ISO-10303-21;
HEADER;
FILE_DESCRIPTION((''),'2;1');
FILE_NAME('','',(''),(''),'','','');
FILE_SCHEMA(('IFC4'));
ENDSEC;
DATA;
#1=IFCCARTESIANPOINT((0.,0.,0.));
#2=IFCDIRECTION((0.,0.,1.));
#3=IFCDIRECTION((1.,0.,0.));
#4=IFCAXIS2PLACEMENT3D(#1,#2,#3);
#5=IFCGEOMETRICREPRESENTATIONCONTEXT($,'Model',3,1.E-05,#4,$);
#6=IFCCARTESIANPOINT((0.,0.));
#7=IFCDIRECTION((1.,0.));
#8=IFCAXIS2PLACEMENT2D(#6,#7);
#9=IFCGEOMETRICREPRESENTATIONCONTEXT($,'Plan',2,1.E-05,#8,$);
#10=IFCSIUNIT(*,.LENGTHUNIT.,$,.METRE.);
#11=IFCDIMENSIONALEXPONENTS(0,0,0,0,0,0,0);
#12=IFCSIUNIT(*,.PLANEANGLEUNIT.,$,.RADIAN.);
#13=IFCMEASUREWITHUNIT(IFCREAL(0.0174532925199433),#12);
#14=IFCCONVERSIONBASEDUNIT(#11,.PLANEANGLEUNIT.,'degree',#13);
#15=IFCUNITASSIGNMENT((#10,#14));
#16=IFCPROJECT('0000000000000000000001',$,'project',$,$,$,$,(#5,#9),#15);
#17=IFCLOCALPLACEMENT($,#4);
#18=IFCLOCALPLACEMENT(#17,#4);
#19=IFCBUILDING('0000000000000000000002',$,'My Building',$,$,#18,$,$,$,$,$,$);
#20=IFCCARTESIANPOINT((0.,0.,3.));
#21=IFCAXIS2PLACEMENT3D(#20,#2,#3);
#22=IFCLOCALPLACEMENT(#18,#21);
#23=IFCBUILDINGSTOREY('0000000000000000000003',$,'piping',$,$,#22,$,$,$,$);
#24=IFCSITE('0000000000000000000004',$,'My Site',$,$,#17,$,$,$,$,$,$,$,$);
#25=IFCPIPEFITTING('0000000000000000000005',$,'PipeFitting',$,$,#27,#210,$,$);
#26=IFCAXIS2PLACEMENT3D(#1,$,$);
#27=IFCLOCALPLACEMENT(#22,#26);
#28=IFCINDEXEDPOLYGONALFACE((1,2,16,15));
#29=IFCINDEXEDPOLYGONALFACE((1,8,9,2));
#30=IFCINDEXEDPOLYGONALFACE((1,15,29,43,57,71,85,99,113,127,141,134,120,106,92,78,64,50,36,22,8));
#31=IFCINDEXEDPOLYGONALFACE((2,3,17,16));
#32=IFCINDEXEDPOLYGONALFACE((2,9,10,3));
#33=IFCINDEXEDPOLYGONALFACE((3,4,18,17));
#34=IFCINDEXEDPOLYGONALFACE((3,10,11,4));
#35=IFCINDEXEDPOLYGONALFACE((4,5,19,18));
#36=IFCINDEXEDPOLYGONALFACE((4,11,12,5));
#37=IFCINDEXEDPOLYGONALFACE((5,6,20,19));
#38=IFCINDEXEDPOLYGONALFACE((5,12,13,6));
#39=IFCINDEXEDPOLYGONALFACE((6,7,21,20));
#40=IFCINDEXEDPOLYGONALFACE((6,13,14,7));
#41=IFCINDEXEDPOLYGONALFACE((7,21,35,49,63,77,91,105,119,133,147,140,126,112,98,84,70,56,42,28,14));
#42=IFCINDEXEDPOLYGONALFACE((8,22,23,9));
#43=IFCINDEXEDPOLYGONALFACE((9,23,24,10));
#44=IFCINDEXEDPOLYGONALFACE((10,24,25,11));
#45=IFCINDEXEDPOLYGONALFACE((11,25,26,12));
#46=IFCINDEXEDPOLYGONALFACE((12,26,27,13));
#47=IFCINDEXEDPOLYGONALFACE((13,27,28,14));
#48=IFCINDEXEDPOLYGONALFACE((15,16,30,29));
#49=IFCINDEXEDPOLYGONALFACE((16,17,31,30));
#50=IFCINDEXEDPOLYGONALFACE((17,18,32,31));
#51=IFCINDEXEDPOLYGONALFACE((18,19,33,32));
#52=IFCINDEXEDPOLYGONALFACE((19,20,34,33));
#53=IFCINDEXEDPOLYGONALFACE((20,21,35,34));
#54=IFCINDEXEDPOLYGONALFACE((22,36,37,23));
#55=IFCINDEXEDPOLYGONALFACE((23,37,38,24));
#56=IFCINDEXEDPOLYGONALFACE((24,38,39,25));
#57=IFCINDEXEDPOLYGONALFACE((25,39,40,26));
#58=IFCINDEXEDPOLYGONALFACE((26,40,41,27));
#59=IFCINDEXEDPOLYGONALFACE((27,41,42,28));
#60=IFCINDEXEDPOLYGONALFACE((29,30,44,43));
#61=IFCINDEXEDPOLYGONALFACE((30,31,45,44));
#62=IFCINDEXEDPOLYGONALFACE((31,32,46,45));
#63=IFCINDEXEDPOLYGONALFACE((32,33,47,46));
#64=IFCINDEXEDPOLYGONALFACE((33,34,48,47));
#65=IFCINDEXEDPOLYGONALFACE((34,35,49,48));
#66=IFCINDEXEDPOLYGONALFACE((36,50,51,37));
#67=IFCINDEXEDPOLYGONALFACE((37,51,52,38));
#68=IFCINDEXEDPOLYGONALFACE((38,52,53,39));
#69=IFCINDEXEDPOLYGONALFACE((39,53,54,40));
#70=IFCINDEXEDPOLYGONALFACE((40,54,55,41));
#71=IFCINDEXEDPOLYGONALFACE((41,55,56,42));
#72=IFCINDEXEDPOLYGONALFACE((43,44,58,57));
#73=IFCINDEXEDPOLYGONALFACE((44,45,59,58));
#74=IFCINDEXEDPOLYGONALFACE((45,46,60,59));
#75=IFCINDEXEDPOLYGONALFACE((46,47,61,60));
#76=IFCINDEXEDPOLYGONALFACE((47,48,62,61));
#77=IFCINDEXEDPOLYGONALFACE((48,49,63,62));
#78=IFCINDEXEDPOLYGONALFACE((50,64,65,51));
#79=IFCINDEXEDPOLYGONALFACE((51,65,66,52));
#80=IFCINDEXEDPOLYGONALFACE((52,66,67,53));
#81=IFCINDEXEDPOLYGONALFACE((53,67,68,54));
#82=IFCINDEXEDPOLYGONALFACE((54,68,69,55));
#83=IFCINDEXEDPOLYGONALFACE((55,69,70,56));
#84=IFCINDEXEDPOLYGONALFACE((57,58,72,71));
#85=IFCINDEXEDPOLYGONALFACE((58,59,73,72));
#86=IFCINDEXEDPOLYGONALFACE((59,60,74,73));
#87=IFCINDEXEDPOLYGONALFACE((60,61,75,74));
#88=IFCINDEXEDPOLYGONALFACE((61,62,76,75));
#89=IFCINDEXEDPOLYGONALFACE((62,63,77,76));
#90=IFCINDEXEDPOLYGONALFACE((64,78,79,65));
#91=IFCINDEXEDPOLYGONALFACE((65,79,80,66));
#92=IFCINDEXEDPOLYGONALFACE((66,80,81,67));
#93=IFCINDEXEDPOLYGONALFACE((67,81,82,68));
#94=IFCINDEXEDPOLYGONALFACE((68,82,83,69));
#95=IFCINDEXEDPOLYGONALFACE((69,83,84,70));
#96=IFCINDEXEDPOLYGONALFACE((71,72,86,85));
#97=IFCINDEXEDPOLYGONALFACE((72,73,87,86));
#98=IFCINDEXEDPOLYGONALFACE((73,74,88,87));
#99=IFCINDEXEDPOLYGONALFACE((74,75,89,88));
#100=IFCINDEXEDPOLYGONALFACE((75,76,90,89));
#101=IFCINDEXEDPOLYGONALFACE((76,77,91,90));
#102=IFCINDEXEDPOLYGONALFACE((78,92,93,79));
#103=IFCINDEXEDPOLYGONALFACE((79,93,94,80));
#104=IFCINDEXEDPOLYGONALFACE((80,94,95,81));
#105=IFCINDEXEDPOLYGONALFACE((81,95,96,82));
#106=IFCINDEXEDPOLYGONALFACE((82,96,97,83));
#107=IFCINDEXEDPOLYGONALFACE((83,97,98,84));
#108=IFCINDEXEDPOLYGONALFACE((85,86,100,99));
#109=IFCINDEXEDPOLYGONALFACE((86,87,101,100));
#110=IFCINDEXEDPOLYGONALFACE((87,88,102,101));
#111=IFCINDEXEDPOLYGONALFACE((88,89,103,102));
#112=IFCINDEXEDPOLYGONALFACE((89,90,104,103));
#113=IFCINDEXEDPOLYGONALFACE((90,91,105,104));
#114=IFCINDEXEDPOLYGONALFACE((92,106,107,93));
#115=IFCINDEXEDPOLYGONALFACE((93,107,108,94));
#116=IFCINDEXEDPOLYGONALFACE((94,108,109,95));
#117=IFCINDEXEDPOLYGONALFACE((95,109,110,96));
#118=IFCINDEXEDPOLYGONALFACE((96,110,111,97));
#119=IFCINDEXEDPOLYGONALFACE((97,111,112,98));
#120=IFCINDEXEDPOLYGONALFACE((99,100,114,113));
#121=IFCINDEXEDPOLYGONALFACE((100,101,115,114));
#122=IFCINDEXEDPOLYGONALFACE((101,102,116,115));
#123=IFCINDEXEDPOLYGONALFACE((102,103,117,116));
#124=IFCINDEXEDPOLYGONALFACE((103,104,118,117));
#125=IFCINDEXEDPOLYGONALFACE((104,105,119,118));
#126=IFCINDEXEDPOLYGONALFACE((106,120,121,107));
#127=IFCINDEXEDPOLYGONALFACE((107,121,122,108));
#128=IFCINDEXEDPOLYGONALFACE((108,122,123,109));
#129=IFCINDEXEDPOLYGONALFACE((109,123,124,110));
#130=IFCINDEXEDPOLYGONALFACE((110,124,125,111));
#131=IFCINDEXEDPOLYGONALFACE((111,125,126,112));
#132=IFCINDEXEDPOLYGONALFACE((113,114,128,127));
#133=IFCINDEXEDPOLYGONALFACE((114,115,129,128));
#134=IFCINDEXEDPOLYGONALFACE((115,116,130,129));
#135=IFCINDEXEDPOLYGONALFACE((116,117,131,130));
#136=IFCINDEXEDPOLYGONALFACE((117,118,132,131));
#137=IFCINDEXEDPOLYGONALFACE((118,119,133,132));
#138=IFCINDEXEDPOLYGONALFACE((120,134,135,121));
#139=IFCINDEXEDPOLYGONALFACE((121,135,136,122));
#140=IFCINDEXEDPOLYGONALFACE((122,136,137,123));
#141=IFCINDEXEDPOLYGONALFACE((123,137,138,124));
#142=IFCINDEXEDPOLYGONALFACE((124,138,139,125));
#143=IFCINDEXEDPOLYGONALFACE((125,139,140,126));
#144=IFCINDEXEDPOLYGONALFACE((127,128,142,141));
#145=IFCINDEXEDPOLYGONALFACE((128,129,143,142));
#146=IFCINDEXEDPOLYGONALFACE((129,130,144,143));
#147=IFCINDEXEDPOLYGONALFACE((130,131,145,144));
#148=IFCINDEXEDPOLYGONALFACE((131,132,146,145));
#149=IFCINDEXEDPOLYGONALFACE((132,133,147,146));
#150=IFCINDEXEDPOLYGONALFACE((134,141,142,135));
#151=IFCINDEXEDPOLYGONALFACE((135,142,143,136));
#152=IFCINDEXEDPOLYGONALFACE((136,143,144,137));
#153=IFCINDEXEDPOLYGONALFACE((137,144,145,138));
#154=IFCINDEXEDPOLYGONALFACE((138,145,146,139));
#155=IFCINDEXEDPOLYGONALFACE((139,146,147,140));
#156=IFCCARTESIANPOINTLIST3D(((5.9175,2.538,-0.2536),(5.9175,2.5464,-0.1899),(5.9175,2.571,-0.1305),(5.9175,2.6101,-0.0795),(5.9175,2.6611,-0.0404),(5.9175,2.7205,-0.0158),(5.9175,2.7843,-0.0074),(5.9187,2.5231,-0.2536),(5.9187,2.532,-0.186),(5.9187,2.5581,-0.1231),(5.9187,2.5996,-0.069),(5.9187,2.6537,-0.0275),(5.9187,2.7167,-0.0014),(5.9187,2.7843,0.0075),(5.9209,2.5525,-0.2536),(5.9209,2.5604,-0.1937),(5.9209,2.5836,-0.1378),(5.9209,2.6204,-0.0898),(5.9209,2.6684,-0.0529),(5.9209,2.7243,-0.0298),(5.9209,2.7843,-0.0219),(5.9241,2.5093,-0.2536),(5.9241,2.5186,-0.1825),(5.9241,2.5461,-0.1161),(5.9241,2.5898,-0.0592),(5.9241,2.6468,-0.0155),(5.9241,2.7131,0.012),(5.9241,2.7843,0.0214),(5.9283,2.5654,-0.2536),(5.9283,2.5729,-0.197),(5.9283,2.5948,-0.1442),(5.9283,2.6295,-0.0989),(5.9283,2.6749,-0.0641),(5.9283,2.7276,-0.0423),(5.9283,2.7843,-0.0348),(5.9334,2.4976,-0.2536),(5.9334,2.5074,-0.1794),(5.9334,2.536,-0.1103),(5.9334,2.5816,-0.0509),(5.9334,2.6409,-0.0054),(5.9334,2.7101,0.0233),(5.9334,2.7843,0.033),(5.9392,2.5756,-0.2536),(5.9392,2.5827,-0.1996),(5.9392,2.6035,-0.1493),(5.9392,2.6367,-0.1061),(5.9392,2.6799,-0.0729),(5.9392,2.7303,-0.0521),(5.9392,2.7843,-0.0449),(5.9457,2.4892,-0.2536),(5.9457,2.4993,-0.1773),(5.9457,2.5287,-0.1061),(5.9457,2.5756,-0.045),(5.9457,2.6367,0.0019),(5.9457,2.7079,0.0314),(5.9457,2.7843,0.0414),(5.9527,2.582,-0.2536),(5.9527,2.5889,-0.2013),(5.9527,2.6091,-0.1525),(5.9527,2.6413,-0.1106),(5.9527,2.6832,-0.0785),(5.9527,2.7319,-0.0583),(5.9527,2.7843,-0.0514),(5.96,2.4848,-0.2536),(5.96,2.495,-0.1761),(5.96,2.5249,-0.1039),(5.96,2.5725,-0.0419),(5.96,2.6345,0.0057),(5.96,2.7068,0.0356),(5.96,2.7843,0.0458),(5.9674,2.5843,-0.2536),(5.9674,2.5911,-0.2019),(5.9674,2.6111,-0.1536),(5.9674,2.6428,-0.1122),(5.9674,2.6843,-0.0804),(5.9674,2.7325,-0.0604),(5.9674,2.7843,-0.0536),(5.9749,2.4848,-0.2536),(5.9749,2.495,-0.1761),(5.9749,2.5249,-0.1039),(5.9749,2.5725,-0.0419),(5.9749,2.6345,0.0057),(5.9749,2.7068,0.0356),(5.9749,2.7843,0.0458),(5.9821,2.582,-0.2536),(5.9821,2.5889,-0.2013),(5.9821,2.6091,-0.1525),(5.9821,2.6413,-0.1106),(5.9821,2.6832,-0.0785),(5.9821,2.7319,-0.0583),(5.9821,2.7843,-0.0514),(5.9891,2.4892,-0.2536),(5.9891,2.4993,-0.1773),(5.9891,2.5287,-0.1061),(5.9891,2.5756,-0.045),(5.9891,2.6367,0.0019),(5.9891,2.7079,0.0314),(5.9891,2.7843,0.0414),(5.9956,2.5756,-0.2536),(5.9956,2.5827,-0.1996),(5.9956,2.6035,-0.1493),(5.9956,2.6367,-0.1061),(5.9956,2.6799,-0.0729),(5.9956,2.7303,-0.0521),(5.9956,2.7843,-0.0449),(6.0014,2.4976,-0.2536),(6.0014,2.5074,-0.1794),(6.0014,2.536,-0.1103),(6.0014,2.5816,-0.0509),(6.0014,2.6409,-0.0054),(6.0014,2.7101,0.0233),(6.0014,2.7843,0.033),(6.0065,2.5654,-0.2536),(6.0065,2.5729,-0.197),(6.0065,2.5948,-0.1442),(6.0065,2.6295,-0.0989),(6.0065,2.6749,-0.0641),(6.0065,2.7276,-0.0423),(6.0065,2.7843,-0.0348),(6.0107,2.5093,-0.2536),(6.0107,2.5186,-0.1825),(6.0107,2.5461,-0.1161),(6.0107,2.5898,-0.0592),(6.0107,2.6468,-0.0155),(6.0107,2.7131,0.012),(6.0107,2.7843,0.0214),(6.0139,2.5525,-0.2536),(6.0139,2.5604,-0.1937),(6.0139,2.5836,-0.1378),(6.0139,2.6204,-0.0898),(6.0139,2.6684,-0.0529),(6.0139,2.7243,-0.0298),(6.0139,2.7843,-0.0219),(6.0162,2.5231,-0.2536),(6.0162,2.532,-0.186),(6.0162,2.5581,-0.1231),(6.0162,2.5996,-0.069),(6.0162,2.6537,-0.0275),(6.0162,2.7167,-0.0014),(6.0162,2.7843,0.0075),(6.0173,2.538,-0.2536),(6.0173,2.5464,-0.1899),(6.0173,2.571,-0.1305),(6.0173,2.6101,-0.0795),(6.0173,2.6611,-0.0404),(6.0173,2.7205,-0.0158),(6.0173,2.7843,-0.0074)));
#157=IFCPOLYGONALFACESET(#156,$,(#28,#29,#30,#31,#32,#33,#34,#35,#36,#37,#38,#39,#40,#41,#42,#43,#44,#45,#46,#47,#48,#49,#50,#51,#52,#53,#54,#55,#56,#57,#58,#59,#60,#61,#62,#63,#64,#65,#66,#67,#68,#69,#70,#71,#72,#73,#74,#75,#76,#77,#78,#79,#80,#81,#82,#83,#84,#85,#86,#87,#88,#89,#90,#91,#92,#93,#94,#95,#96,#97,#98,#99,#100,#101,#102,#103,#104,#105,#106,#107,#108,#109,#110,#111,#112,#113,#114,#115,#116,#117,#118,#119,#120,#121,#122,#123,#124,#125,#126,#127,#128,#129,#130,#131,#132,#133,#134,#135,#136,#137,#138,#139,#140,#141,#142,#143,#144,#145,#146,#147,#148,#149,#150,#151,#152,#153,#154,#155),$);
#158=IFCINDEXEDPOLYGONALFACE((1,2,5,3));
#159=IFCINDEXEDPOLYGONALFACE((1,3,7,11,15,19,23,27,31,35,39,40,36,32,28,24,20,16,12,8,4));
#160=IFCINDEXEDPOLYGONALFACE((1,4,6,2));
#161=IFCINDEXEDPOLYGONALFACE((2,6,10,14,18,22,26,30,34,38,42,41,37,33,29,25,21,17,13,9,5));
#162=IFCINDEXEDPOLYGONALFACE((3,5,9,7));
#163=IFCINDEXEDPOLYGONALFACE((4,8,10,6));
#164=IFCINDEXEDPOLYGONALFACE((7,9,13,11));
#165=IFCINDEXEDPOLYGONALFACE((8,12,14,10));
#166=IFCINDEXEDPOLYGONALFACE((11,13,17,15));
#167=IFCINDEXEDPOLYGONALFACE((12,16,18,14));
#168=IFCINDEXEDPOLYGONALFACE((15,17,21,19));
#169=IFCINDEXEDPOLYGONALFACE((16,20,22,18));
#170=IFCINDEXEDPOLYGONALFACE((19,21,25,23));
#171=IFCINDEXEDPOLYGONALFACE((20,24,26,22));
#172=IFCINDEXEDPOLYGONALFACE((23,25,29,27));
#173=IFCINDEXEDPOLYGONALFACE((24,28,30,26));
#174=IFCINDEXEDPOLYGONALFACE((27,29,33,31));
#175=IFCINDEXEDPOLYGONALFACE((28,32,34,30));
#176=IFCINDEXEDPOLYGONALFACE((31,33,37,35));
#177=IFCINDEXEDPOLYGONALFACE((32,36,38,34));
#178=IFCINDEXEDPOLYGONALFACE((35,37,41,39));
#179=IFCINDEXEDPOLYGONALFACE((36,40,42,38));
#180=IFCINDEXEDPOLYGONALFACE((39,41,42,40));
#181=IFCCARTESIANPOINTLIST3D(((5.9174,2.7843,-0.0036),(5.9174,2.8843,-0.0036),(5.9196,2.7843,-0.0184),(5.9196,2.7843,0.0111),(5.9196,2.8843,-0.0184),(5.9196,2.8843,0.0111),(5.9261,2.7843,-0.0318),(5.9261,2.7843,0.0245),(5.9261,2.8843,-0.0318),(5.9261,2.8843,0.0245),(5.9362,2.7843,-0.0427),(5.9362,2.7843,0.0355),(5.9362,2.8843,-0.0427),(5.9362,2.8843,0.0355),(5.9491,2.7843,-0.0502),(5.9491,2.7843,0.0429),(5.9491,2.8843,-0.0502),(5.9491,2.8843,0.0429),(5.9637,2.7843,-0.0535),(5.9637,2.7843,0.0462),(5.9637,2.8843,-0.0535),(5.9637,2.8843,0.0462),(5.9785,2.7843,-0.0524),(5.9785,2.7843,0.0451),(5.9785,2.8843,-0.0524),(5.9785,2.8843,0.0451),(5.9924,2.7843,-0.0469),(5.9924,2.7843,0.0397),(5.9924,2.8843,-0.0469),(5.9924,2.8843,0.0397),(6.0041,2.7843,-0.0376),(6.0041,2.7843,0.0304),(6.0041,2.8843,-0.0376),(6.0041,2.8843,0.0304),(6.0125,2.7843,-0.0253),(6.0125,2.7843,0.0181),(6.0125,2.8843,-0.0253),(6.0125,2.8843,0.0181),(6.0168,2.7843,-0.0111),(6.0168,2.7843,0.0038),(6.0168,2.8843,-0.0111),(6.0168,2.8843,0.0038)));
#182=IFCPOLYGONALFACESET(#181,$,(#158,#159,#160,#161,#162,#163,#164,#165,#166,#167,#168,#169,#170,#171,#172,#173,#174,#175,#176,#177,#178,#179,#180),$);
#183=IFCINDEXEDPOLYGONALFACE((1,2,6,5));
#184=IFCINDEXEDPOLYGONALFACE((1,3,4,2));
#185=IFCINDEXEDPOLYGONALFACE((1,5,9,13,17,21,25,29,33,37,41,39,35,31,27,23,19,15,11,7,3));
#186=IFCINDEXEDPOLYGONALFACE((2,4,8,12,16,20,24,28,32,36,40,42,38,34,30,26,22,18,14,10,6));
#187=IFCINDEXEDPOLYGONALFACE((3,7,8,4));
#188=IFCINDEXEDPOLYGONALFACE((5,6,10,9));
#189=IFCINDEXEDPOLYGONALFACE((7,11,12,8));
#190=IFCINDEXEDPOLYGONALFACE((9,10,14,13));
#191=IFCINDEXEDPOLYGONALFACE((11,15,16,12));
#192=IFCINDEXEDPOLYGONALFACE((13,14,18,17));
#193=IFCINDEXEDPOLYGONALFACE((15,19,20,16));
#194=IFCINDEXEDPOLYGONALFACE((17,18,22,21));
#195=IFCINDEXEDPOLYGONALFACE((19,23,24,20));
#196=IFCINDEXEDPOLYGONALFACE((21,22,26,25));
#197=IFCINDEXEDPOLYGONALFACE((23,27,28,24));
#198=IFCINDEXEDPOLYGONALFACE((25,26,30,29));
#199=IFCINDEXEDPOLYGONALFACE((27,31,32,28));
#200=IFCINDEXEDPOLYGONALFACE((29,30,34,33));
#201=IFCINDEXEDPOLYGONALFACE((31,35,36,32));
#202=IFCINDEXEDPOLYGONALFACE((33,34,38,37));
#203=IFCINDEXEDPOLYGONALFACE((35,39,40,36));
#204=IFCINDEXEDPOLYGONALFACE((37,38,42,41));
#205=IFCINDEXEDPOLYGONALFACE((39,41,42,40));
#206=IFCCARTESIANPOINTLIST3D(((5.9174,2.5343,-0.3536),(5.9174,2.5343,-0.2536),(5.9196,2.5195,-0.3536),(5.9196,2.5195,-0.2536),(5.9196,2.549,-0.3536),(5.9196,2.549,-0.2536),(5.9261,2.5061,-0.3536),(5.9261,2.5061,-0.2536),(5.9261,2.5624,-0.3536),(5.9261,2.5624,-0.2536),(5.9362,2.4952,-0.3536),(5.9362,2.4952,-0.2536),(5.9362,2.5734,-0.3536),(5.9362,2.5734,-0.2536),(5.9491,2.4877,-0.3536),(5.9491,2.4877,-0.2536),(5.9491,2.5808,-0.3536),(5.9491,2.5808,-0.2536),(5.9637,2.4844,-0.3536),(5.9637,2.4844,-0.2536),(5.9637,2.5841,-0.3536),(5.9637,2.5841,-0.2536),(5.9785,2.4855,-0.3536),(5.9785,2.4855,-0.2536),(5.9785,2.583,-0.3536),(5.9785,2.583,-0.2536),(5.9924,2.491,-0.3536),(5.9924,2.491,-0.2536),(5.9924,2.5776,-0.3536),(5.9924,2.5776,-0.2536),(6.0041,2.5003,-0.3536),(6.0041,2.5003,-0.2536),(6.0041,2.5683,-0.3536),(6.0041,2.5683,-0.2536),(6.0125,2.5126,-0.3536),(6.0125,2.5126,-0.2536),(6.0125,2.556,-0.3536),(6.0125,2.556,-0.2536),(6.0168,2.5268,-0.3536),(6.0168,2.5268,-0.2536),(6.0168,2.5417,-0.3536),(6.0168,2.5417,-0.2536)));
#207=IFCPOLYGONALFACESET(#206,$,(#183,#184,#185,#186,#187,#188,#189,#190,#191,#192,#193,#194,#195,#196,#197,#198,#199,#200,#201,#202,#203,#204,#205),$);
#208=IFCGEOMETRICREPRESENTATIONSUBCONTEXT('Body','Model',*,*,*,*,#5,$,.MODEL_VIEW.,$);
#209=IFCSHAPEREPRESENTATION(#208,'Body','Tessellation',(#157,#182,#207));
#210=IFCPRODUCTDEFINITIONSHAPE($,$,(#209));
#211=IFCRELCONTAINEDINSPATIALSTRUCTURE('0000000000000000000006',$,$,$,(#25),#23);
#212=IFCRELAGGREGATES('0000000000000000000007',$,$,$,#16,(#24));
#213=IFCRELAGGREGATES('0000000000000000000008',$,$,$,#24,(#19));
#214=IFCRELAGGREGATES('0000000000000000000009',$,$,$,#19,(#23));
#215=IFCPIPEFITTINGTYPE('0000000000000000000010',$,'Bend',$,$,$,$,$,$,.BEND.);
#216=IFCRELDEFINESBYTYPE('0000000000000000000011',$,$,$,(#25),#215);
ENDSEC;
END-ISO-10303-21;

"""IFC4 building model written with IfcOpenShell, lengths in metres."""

from ifc_helpers import new_model, entity, si_unit, converted_unit, frame, origin_with_axes, origin_2d_with_axis, place, context, subcontext, project, spatial, circle, extrude, source, transform, mapped, type_object, type_shapes, element, save


model = new_model("IFC4")

# Units and contexts
model_context = context("Model", 3, precision=1e-05, world=origin_with_axes())
plan_context = context("Plan", 2, precision=1e-05, world=origin_2d_with_axis())
body_context = subcontext(model_context, "Body", "Model", "MODEL_VIEW")
ifc_project = project(units=[si_unit("LENGTHUNIT", "METRE"), converted_unit("PLANEANGLEUNIT", "degree", entity("IfcReal", 0.0174532925199433), si_unit("PLANEANGLEUNIT", "RADIAN"), dimensions=[0, 0, 0, 0, 0, 0, 0])], contexts=[model_context, plan_context])

# Site, building, storey
site_placement = place(None, origin_with_axes())
site = spatial("IfcSite", under=ifc_project, at=site_placement, Name="My Site")
building_placement = place(site_placement, origin_with_axes())
building = spatial("IfcBuilding", under=site, at=building_placement, Name="My Building")
storey_placement = place(building_placement, frame((0.0, 0.0, 3.0), z_axis=(0.0, 0.0, 1.0), x_axis=(1.0, 0.0, 0.0)))
storey = spatial("IfcBuildingStorey", under=building, at=storey_placement, Name="piping")

# Pipe fitting
pipe_fitting_type = type_object("IfcPipeFittingType", Name="Bend", PredefinedType="BEND")
shared_shape = source(origin_with_axes(), body_context, "Body", "SolidModel", [
    entity("IfcSweptDiskSolid", entity("IfcIndexedPolyCurve", entity("IfcCartesianPointList3D", [[0.0, 0.0, -0.1], [0.0, -0.0732, -0.2768], [0.0, -0.25, -0.35]]), [entity("IfcArcIndex", [1, 2, 3])]), 0.05),
    extrude(circle(Radius=0.05), origin_with_axes(), (0.0, 0.0, -1.0), 0.1),
    extrude(circle(Radius=0.05), frame((0.0, -0.25, -0.35), z_axis=(0.0, -1.0, 0.0), x_axis=(1.0, 0.0, 0.0)), (0.0, 0.0, 1.0), 0.1),
])
type_shapes(pipe_fitting_type, [shared_shape])
for number, where, z_axis, x_axis, name in (
    (1, (5.9674, 2.8843, -0.0036), (0.0, 1.0, 0.0), (-1.0, 0.0, 0.0), "PipeFitting"),
):
    element("IfcPipeFitting", number, at=place(storey_placement, frame(where, z_axis=z_axis, x_axis=x_axis)), inside=storey, type_object=pipe_fitting_type, Name=name, context=body_context, shape_type="MappedRepresentation", body=[
        mapped(shared_shape, transform((0.0, 0.0, 0.0), x_axis=(1.0, 0.0, 0.0), y_axis=(0.0, 1.0, 0.0), z_axis=(0.0, 0.0, 1.0), scale=1.0)),
    ])

save(model, "model.ifc")
